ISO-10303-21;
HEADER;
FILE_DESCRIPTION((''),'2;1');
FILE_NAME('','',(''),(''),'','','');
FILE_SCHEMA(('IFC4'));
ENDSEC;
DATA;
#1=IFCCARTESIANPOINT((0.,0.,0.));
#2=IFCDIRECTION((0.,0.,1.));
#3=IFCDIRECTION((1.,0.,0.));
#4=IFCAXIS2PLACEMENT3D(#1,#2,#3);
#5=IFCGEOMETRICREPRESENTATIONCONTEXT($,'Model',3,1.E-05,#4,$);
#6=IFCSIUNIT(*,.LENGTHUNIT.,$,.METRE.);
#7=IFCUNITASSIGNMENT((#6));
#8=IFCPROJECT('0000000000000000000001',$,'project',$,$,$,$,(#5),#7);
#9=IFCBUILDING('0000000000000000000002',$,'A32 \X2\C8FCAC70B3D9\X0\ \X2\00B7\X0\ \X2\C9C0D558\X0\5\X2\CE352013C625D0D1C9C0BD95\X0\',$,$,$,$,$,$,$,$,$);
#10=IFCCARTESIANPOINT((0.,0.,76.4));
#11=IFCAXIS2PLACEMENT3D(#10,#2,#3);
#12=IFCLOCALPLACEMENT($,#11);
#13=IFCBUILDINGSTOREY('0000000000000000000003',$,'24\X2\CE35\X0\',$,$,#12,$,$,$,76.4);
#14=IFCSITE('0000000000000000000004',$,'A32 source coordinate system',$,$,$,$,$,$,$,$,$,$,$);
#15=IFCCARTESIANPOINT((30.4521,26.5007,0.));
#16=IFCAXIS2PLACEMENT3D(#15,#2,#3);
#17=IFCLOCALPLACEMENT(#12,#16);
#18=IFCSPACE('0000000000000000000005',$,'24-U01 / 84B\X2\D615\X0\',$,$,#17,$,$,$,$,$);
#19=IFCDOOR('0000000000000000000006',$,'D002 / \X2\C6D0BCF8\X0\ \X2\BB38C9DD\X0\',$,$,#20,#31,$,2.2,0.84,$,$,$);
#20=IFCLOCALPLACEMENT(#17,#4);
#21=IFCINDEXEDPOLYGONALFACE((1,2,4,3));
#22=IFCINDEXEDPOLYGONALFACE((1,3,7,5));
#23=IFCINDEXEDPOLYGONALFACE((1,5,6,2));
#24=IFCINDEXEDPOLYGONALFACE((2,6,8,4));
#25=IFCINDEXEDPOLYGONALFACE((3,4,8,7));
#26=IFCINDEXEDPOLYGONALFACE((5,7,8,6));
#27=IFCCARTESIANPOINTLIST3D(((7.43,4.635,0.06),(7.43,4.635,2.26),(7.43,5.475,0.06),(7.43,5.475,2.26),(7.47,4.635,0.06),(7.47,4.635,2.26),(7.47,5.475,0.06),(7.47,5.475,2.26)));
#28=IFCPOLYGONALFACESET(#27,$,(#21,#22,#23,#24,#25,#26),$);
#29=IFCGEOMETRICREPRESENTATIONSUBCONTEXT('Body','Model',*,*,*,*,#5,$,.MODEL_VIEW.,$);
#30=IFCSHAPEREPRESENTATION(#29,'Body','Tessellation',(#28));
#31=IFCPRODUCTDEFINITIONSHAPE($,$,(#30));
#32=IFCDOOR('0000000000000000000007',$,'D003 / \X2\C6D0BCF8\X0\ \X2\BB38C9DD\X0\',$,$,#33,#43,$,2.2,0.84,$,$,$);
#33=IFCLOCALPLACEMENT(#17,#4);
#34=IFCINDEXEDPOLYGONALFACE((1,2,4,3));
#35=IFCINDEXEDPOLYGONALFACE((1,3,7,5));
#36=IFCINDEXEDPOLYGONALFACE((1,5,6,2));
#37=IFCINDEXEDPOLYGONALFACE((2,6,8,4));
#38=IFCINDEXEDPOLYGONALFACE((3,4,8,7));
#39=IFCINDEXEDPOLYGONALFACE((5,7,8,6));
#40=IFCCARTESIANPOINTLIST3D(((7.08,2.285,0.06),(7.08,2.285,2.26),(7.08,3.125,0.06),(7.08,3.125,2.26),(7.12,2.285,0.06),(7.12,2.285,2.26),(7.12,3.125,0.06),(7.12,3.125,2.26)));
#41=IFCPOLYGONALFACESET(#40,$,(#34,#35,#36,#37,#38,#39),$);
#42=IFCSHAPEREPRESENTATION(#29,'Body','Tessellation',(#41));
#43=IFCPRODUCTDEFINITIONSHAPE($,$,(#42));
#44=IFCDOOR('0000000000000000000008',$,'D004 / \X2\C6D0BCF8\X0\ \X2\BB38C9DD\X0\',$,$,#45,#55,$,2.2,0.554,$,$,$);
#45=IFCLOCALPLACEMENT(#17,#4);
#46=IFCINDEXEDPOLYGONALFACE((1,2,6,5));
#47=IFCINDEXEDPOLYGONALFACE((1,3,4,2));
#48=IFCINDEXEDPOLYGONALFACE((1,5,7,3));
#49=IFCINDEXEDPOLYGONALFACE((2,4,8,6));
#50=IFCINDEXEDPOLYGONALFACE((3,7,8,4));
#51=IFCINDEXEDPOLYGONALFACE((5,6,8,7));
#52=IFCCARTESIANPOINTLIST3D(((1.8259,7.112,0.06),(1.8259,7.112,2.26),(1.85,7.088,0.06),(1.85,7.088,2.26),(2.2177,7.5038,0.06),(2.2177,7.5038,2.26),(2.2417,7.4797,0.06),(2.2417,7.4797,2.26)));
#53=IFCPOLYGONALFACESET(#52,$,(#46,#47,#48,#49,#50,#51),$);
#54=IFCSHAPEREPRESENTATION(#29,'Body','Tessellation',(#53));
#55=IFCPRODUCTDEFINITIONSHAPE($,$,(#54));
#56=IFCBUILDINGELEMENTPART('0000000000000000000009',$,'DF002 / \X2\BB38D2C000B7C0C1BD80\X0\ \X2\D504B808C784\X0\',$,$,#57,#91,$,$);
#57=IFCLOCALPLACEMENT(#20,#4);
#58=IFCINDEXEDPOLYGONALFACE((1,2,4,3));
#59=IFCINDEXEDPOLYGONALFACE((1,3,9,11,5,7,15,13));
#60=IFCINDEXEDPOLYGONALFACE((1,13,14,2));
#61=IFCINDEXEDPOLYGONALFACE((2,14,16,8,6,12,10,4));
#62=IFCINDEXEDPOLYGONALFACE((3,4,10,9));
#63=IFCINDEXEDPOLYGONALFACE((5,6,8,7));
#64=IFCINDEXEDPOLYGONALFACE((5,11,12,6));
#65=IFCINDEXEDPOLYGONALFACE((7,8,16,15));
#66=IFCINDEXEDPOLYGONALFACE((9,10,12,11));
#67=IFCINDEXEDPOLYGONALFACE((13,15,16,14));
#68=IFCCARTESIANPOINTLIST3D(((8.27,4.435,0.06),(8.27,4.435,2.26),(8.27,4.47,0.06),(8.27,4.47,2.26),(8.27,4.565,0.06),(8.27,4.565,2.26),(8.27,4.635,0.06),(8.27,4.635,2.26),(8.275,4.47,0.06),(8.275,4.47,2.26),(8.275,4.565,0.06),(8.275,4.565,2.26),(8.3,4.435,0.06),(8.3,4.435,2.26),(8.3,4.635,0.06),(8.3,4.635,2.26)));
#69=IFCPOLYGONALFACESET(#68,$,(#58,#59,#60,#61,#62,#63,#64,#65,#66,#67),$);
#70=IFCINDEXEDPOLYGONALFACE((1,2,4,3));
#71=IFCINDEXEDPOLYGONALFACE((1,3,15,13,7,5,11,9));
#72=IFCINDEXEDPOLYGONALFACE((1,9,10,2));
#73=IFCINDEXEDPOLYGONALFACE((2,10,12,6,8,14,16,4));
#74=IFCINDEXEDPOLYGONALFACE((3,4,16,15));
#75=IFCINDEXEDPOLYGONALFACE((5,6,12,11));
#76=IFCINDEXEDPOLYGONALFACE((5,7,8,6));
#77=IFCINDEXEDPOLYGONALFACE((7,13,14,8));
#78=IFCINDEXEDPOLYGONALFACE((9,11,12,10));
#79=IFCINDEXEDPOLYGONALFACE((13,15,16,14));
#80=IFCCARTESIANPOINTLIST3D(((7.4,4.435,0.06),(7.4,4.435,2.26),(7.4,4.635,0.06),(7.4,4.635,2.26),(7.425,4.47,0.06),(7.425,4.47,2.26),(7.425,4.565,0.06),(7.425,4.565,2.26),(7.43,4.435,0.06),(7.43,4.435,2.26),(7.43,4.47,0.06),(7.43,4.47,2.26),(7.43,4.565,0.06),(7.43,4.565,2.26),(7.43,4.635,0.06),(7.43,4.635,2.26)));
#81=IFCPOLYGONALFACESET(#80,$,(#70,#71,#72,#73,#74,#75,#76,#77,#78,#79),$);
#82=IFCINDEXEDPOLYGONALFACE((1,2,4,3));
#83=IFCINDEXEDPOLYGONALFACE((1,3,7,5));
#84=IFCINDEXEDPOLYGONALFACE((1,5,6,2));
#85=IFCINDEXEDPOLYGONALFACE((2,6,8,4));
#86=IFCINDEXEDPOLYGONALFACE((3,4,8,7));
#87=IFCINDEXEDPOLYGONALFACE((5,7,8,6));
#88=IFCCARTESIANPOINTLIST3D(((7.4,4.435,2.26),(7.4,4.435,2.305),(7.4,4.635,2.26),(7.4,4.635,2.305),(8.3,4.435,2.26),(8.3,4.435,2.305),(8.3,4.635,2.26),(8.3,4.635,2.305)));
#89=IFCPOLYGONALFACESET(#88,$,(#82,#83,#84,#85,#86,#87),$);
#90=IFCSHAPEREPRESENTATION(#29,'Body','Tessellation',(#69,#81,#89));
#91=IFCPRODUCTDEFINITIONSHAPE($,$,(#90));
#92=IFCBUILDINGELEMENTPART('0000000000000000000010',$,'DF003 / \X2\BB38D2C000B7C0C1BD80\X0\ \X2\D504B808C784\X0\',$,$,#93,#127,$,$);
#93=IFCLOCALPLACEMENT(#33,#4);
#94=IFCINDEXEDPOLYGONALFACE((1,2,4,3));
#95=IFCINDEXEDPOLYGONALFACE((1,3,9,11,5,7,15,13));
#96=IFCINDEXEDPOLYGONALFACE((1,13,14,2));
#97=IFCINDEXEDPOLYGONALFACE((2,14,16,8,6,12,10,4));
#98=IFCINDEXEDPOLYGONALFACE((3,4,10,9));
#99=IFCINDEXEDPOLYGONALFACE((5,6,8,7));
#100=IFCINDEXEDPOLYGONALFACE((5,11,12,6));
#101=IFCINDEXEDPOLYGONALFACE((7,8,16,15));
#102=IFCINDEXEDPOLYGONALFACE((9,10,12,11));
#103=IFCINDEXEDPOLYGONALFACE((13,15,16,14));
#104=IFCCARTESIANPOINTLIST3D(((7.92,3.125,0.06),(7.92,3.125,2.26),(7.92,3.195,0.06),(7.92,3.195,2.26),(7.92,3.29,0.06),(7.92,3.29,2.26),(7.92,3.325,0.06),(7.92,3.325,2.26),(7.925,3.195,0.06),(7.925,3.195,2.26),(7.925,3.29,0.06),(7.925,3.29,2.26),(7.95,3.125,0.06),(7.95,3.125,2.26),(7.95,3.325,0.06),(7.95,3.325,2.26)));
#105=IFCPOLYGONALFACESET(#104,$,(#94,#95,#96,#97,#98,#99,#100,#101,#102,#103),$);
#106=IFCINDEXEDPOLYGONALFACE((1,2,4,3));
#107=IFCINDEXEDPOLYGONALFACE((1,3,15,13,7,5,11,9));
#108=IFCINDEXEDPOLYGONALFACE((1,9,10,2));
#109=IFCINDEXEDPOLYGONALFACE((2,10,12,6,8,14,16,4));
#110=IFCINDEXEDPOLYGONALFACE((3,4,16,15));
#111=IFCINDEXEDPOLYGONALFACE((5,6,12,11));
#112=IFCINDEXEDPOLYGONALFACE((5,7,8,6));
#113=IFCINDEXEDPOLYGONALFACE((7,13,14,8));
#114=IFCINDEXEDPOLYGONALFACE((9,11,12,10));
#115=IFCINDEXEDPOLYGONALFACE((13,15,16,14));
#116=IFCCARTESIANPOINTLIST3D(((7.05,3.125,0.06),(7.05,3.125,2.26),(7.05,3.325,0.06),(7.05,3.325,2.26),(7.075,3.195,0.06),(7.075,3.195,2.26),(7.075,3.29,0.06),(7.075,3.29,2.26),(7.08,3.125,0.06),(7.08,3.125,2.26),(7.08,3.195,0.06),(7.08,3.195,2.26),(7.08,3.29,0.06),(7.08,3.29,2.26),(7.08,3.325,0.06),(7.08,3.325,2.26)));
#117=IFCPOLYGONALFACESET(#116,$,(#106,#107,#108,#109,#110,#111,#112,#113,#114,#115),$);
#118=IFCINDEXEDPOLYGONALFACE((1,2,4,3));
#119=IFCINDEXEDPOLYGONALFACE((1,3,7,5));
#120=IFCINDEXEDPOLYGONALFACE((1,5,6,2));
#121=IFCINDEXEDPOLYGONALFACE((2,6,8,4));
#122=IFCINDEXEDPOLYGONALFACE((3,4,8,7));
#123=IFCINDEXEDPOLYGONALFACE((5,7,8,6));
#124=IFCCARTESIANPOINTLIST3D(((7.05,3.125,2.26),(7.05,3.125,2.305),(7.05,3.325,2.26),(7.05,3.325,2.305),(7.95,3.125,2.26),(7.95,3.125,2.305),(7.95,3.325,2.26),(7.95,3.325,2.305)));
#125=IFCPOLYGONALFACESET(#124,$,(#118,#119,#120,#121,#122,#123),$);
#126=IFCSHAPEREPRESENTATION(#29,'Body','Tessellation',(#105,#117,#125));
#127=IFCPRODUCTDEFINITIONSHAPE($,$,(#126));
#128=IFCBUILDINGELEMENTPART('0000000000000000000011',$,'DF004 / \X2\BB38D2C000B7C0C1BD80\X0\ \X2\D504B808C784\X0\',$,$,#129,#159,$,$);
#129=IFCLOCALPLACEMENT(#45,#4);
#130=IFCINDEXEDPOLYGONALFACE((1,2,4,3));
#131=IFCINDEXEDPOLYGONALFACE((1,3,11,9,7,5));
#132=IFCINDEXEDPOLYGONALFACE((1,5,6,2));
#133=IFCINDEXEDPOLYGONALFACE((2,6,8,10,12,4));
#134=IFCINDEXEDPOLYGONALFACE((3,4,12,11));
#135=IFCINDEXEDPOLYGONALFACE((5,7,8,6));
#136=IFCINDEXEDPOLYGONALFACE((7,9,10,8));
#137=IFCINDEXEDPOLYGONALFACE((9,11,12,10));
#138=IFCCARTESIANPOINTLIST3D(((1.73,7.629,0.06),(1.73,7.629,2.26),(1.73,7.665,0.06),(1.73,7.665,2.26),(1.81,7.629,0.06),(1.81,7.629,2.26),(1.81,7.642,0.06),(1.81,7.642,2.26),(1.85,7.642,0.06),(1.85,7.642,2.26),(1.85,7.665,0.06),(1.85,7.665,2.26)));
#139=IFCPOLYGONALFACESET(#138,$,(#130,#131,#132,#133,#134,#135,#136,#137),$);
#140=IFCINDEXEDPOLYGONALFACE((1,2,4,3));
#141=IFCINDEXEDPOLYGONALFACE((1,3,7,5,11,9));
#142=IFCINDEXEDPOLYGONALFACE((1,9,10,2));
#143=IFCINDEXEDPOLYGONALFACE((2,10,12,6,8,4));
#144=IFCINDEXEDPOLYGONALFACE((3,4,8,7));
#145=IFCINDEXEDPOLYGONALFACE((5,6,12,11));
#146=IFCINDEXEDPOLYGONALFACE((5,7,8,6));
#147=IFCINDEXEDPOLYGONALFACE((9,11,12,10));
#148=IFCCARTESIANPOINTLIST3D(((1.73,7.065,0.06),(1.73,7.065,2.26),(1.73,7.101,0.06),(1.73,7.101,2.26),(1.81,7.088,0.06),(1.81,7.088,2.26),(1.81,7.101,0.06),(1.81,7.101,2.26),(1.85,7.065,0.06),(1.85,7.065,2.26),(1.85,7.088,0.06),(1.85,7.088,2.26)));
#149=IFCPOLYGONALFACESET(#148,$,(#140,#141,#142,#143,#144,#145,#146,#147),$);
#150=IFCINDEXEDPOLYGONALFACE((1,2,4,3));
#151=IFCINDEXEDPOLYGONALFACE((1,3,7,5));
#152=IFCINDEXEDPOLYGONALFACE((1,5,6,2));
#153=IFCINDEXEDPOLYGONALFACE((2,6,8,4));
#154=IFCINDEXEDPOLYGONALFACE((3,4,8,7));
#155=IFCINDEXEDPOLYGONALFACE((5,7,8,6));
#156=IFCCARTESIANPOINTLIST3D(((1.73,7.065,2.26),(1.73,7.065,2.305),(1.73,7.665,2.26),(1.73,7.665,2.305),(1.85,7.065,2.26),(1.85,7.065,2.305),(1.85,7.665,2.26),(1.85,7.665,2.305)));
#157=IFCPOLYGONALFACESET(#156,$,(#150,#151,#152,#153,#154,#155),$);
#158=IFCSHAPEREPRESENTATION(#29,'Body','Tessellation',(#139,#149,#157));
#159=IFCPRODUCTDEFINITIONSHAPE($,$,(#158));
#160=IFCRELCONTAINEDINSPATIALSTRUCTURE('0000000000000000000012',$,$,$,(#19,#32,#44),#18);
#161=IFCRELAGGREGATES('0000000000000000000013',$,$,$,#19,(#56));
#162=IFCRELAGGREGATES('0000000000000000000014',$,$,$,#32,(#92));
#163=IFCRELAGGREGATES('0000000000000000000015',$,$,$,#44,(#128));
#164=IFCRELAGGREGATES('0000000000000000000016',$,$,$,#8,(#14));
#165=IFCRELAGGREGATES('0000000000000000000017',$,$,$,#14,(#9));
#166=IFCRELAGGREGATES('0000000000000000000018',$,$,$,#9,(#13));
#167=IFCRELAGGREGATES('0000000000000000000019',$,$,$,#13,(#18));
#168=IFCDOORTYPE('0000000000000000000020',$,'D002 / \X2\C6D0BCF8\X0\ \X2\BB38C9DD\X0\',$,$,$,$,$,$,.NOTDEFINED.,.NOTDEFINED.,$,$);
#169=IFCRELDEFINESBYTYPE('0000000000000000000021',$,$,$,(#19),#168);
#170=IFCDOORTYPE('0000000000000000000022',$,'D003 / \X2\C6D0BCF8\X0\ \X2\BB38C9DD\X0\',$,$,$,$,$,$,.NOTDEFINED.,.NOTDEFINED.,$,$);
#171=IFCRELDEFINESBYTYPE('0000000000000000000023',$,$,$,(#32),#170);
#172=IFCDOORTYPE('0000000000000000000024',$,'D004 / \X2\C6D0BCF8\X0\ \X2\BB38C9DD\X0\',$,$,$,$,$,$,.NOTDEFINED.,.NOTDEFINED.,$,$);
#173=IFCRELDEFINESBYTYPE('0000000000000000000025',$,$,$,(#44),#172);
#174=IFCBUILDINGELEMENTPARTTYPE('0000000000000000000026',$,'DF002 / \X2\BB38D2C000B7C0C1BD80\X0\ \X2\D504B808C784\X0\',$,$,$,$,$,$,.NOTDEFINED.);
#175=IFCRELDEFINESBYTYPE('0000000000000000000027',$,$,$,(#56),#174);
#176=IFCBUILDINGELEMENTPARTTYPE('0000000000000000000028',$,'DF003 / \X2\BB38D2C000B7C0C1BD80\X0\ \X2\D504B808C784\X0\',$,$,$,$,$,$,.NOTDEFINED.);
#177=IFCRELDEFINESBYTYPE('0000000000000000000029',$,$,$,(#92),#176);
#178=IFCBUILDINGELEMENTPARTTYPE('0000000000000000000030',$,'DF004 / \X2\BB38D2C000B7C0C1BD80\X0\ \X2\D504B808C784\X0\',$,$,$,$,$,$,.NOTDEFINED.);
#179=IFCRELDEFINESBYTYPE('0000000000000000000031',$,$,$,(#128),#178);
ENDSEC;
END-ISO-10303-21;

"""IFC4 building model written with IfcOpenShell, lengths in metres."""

from ifc_helpers import new_model, si_unit, frame, origin, origin_with_axes, place, context, subcontext, project, spatial, polyline, outline, extrude, source, transform, mapped, type_object, type_shapes, element, aggregate, save


model = new_model("IFC4")

# Units and contexts
model_context = context("Model", 3, precision=1e-05, world=origin_with_axes())
body_context = subcontext(model_context, "Body", "Model", "MODEL_VIEW")
ifc_project = project(units=[si_unit("LENGTHUNIT", "METRE")], contexts=[model_context])

# Site, building, storey, space
storey_placement = place(None, frame((0.0, 0.0, 76.4), z_axis=(0.0, 0.0, 1.0), x_axis=(1.0, 0.0, 0.0)))
space_placement = place(storey_placement, frame((30.4521, 26.5007, 0.0), z_axis=(0.0, 0.0, 1.0), x_axis=(1.0, 0.0, 0.0)))
site = spatial("IfcSite", under=ifc_project, Name="A32 source coordinate system")
building = spatial("IfcBuilding", under=site, Name="A32 주거동 · 지하5층–옥탑지붕")
storey = spatial("IfcBuildingStorey", under=building, at=storey_placement, Name="24층", Elevation=76.4)
space = spatial("IfcSpace", under=storey, at=space_placement, Name="24-U01 / 84B형")

# Doors
door_type_1 = type_object("IfcDoorType", Name="D002 / 원본 문짝", OperationType="NOTDEFINED", PredefinedType="NOTDEFINED")
shared_shape_1 = source(origin(), body_context, "Body", "SweptSolid", [
    extrude(outline(polyline([(7.43, 4.635), (7.43, 5.475), (7.47, 5.475), (7.47, 4.635), (7.43, 4.635)])), frame((0.0, 0.0, 0.06)), (0.0, 0.0, 1.0), 2.2),
])
type_shapes(door_type_1, [shared_shape_1])
door_1_placement = place(space_placement, origin_with_axes())
door_1 = element("IfcDoor", 1, at=door_1_placement, inside=space, type_object=door_type_1, Name="D002 / 원본 문짝", OverallHeight=2.2, OverallWidth=0.84, context=body_context, shape_type="MappedRepresentation", body=[
    mapped(shared_shape_1, transform((0.0, 0.0, 0.0), scale=1.0)),
])
door_type_2 = type_object("IfcDoorType", Name="D003 / 원본 문짝", OperationType="NOTDEFINED", PredefinedType="NOTDEFINED")
shared_shape_2 = source(origin(), body_context, "Body", "SweptSolid", [
    extrude(outline(polyline([(7.12, 2.285), (7.08, 2.285), (7.08, 3.125), (7.12, 3.125), (7.12, 2.285)])), frame((0.0, 0.0, 0.06)), (0.0, 0.0, 1.0), 2.2),
])
type_shapes(door_type_2, [shared_shape_2])
door_2_placement = place(space_placement, origin_with_axes())
door_2 = element("IfcDoor", 2, at=door_2_placement, inside=space, type_object=door_type_2, Name="D003 / 원본 문짝", OverallHeight=2.2, OverallWidth=0.84, context=body_context, shape_type="MappedRepresentation", body=[
    mapped(shared_shape_2, transform((0.0, 0.0, 0.0), scale=1.0)),
])
door_type_3 = type_object("IfcDoorType", Name="D004 / 원본 문짝", OperationType="NOTDEFINED", PredefinedType="NOTDEFINED")
shared_shape_3 = source(origin(), body_context, "Body", "SweptSolid", [
    extrude(outline(polyline([(2.2177, 7.5038), (2.2417, 7.4797), (1.85, 7.088), (1.8259, 7.112), (2.2177, 7.5038)])), frame((0.0, 0.0, 0.06)), (0.0, 0.0, 1.0), 2.2),
])
type_shapes(door_type_3, [shared_shape_3])
door_3_placement = place(space_placement, origin_with_axes())
door_3 = element("IfcDoor", 3, at=door_3_placement, inside=space, type_object=door_type_3, Name="D004 / 원본 문짝", OverallHeight=2.2, OverallWidth=0.554, context=body_context, shape_type="MappedRepresentation", body=[
    mapped(shared_shape_3, transform((0.0, 0.0, 0.0), scale=1.0)),
])

# Building element parts
building_element_part_type_1 = type_object("IfcBuildingElementPartType", Name="DF002 / 문틀·상부 프레임", PredefinedType="NOTDEFINED")
shared_shape_4 = source(origin(), body_context, "Body", "SweptSolid", [
    extrude(outline(polyline([(8.3, 4.435), (8.27, 4.435), (8.27, 4.47), (8.275, 4.47), (8.275, 4.565), (8.27, 4.565), (8.27, 4.635), (8.3, 4.635), (8.3, 4.435)])), frame((0.0, 0.0, 0.06)), (0.0, 0.0, 1.0), 2.2),
    extrude(outline(polyline([(7.43, 4.635), (7.43, 4.565), (7.425, 4.565), (7.425, 4.47), (7.43, 4.47), (7.43, 4.435), (7.4, 4.435), (7.4, 4.635), (7.43, 4.635)])), frame((0.0, 0.0, 0.06)), (0.0, 0.0, 1.0), 2.2),
    extrude(outline(polyline([(7.4, 4.435), (7.4, 4.635), (8.3, 4.635), (8.3, 4.435), (7.4, 4.435)])), frame((0.0, 0.0, 2.26)), (0.0, 0.0, 1.0), 0.045),
])
type_shapes(building_element_part_type_1, [shared_shape_4])
building_element_part_1_placement = place(door_1_placement, origin_with_axes())
building_element_part_1 = element("IfcBuildingElementPart", 4, at=building_element_part_1_placement, type_object=building_element_part_type_1, Name="DF002 / 문틀·상부 프레임", context=body_context, shape_type="MappedRepresentation", body=[
    mapped(shared_shape_4, transform((0.0, 0.0, 0.0), scale=1.0)),
])
aggregate(door_1, [building_element_part_1])
building_element_part_type_2 = type_object("IfcBuildingElementPartType", Name="DF003 / 문틀·상부 프레임", PredefinedType="NOTDEFINED")
shared_shape_5 = source(origin(), body_context, "Body", "SweptSolid", [
    extrude(outline(polyline([(7.92, 3.125), (7.92, 3.195), (7.925, 3.195), (7.925, 3.29), (7.92, 3.29), (7.92, 3.325), (7.95, 3.325), (7.95, 3.125), (7.92, 3.125)])), frame((0.0, 0.0, 0.06)), (0.0, 0.0, 1.0), 2.2),
    extrude(outline(polyline([(7.05, 3.325), (7.08, 3.325), (7.08, 3.29), (7.075, 3.29), (7.075, 3.195), (7.08, 3.195), (7.08, 3.125), (7.05, 3.125), (7.05, 3.325)])), frame((0.0, 0.0, 0.06)), (0.0, 0.0, 1.0), 2.2),
    extrude(outline(polyline([(7.05, 3.125), (7.05, 3.325), (7.95, 3.325), (7.95, 3.125), (7.05, 3.125)])), frame((0.0, 0.0, 2.26)), (0.0, 0.0, 1.0), 0.045),
])
type_shapes(building_element_part_type_2, [shared_shape_5])
building_element_part_2_placement = place(door_2_placement, origin_with_axes())
building_element_part_2 = element("IfcBuildingElementPart", 5, at=building_element_part_2_placement, type_object=building_element_part_type_2, Name="DF003 / 문틀·상부 프레임", context=body_context, shape_type="MappedRepresentation", body=[
    mapped(shared_shape_5, transform((0.0, 0.0, 0.0), scale=1.0)),
])
aggregate(door_2, [building_element_part_2])
building_element_part_type_3 = type_object("IfcBuildingElementPartType", Name="DF004 / 문틀·상부 프레임", PredefinedType="NOTDEFINED")
shared_shape_6 = source(origin(), body_context, "Body", "SweptSolid", [
    extrude(outline(polyline([(1.85, 7.665), (1.85, 7.642), (1.81, 7.642), (1.81, 7.629), (1.73, 7.629), (1.73, 7.665), (1.85, 7.665)])), frame((0.0, 0.0, 0.06)), (0.0, 0.0, 1.0), 2.2),
    extrude(outline(polyline([(1.73, 7.101), (1.81, 7.101), (1.81, 7.088), (1.85, 7.088), (1.85, 7.065), (1.73, 7.065), (1.73, 7.101)])), frame((0.0, 0.0, 0.06)), (0.0, 0.0, 1.0), 2.2),
    extrude(outline(polyline([(1.73, 7.065), (1.73, 7.665), (1.85, 7.665), (1.85, 7.065), (1.73, 7.065)])), frame((0.0, 0.0, 2.26)), (0.0, 0.0, 1.0), 0.045),
])
type_shapes(building_element_part_type_3, [shared_shape_6])
building_element_part_3_placement = place(door_3_placement, origin_with_axes())
building_element_part_3 = element("IfcBuildingElementPart", 6, at=building_element_part_3_placement, type_object=building_element_part_type_3, Name="DF004 / 문틀·상부 프레임", context=body_context, shape_type="MappedRepresentation", body=[
    mapped(shared_shape_6, transform((0.0, 0.0, 0.0), scale=1.0)),
])
aggregate(door_3, [building_element_part_3])

save(model, "model.ifc")
